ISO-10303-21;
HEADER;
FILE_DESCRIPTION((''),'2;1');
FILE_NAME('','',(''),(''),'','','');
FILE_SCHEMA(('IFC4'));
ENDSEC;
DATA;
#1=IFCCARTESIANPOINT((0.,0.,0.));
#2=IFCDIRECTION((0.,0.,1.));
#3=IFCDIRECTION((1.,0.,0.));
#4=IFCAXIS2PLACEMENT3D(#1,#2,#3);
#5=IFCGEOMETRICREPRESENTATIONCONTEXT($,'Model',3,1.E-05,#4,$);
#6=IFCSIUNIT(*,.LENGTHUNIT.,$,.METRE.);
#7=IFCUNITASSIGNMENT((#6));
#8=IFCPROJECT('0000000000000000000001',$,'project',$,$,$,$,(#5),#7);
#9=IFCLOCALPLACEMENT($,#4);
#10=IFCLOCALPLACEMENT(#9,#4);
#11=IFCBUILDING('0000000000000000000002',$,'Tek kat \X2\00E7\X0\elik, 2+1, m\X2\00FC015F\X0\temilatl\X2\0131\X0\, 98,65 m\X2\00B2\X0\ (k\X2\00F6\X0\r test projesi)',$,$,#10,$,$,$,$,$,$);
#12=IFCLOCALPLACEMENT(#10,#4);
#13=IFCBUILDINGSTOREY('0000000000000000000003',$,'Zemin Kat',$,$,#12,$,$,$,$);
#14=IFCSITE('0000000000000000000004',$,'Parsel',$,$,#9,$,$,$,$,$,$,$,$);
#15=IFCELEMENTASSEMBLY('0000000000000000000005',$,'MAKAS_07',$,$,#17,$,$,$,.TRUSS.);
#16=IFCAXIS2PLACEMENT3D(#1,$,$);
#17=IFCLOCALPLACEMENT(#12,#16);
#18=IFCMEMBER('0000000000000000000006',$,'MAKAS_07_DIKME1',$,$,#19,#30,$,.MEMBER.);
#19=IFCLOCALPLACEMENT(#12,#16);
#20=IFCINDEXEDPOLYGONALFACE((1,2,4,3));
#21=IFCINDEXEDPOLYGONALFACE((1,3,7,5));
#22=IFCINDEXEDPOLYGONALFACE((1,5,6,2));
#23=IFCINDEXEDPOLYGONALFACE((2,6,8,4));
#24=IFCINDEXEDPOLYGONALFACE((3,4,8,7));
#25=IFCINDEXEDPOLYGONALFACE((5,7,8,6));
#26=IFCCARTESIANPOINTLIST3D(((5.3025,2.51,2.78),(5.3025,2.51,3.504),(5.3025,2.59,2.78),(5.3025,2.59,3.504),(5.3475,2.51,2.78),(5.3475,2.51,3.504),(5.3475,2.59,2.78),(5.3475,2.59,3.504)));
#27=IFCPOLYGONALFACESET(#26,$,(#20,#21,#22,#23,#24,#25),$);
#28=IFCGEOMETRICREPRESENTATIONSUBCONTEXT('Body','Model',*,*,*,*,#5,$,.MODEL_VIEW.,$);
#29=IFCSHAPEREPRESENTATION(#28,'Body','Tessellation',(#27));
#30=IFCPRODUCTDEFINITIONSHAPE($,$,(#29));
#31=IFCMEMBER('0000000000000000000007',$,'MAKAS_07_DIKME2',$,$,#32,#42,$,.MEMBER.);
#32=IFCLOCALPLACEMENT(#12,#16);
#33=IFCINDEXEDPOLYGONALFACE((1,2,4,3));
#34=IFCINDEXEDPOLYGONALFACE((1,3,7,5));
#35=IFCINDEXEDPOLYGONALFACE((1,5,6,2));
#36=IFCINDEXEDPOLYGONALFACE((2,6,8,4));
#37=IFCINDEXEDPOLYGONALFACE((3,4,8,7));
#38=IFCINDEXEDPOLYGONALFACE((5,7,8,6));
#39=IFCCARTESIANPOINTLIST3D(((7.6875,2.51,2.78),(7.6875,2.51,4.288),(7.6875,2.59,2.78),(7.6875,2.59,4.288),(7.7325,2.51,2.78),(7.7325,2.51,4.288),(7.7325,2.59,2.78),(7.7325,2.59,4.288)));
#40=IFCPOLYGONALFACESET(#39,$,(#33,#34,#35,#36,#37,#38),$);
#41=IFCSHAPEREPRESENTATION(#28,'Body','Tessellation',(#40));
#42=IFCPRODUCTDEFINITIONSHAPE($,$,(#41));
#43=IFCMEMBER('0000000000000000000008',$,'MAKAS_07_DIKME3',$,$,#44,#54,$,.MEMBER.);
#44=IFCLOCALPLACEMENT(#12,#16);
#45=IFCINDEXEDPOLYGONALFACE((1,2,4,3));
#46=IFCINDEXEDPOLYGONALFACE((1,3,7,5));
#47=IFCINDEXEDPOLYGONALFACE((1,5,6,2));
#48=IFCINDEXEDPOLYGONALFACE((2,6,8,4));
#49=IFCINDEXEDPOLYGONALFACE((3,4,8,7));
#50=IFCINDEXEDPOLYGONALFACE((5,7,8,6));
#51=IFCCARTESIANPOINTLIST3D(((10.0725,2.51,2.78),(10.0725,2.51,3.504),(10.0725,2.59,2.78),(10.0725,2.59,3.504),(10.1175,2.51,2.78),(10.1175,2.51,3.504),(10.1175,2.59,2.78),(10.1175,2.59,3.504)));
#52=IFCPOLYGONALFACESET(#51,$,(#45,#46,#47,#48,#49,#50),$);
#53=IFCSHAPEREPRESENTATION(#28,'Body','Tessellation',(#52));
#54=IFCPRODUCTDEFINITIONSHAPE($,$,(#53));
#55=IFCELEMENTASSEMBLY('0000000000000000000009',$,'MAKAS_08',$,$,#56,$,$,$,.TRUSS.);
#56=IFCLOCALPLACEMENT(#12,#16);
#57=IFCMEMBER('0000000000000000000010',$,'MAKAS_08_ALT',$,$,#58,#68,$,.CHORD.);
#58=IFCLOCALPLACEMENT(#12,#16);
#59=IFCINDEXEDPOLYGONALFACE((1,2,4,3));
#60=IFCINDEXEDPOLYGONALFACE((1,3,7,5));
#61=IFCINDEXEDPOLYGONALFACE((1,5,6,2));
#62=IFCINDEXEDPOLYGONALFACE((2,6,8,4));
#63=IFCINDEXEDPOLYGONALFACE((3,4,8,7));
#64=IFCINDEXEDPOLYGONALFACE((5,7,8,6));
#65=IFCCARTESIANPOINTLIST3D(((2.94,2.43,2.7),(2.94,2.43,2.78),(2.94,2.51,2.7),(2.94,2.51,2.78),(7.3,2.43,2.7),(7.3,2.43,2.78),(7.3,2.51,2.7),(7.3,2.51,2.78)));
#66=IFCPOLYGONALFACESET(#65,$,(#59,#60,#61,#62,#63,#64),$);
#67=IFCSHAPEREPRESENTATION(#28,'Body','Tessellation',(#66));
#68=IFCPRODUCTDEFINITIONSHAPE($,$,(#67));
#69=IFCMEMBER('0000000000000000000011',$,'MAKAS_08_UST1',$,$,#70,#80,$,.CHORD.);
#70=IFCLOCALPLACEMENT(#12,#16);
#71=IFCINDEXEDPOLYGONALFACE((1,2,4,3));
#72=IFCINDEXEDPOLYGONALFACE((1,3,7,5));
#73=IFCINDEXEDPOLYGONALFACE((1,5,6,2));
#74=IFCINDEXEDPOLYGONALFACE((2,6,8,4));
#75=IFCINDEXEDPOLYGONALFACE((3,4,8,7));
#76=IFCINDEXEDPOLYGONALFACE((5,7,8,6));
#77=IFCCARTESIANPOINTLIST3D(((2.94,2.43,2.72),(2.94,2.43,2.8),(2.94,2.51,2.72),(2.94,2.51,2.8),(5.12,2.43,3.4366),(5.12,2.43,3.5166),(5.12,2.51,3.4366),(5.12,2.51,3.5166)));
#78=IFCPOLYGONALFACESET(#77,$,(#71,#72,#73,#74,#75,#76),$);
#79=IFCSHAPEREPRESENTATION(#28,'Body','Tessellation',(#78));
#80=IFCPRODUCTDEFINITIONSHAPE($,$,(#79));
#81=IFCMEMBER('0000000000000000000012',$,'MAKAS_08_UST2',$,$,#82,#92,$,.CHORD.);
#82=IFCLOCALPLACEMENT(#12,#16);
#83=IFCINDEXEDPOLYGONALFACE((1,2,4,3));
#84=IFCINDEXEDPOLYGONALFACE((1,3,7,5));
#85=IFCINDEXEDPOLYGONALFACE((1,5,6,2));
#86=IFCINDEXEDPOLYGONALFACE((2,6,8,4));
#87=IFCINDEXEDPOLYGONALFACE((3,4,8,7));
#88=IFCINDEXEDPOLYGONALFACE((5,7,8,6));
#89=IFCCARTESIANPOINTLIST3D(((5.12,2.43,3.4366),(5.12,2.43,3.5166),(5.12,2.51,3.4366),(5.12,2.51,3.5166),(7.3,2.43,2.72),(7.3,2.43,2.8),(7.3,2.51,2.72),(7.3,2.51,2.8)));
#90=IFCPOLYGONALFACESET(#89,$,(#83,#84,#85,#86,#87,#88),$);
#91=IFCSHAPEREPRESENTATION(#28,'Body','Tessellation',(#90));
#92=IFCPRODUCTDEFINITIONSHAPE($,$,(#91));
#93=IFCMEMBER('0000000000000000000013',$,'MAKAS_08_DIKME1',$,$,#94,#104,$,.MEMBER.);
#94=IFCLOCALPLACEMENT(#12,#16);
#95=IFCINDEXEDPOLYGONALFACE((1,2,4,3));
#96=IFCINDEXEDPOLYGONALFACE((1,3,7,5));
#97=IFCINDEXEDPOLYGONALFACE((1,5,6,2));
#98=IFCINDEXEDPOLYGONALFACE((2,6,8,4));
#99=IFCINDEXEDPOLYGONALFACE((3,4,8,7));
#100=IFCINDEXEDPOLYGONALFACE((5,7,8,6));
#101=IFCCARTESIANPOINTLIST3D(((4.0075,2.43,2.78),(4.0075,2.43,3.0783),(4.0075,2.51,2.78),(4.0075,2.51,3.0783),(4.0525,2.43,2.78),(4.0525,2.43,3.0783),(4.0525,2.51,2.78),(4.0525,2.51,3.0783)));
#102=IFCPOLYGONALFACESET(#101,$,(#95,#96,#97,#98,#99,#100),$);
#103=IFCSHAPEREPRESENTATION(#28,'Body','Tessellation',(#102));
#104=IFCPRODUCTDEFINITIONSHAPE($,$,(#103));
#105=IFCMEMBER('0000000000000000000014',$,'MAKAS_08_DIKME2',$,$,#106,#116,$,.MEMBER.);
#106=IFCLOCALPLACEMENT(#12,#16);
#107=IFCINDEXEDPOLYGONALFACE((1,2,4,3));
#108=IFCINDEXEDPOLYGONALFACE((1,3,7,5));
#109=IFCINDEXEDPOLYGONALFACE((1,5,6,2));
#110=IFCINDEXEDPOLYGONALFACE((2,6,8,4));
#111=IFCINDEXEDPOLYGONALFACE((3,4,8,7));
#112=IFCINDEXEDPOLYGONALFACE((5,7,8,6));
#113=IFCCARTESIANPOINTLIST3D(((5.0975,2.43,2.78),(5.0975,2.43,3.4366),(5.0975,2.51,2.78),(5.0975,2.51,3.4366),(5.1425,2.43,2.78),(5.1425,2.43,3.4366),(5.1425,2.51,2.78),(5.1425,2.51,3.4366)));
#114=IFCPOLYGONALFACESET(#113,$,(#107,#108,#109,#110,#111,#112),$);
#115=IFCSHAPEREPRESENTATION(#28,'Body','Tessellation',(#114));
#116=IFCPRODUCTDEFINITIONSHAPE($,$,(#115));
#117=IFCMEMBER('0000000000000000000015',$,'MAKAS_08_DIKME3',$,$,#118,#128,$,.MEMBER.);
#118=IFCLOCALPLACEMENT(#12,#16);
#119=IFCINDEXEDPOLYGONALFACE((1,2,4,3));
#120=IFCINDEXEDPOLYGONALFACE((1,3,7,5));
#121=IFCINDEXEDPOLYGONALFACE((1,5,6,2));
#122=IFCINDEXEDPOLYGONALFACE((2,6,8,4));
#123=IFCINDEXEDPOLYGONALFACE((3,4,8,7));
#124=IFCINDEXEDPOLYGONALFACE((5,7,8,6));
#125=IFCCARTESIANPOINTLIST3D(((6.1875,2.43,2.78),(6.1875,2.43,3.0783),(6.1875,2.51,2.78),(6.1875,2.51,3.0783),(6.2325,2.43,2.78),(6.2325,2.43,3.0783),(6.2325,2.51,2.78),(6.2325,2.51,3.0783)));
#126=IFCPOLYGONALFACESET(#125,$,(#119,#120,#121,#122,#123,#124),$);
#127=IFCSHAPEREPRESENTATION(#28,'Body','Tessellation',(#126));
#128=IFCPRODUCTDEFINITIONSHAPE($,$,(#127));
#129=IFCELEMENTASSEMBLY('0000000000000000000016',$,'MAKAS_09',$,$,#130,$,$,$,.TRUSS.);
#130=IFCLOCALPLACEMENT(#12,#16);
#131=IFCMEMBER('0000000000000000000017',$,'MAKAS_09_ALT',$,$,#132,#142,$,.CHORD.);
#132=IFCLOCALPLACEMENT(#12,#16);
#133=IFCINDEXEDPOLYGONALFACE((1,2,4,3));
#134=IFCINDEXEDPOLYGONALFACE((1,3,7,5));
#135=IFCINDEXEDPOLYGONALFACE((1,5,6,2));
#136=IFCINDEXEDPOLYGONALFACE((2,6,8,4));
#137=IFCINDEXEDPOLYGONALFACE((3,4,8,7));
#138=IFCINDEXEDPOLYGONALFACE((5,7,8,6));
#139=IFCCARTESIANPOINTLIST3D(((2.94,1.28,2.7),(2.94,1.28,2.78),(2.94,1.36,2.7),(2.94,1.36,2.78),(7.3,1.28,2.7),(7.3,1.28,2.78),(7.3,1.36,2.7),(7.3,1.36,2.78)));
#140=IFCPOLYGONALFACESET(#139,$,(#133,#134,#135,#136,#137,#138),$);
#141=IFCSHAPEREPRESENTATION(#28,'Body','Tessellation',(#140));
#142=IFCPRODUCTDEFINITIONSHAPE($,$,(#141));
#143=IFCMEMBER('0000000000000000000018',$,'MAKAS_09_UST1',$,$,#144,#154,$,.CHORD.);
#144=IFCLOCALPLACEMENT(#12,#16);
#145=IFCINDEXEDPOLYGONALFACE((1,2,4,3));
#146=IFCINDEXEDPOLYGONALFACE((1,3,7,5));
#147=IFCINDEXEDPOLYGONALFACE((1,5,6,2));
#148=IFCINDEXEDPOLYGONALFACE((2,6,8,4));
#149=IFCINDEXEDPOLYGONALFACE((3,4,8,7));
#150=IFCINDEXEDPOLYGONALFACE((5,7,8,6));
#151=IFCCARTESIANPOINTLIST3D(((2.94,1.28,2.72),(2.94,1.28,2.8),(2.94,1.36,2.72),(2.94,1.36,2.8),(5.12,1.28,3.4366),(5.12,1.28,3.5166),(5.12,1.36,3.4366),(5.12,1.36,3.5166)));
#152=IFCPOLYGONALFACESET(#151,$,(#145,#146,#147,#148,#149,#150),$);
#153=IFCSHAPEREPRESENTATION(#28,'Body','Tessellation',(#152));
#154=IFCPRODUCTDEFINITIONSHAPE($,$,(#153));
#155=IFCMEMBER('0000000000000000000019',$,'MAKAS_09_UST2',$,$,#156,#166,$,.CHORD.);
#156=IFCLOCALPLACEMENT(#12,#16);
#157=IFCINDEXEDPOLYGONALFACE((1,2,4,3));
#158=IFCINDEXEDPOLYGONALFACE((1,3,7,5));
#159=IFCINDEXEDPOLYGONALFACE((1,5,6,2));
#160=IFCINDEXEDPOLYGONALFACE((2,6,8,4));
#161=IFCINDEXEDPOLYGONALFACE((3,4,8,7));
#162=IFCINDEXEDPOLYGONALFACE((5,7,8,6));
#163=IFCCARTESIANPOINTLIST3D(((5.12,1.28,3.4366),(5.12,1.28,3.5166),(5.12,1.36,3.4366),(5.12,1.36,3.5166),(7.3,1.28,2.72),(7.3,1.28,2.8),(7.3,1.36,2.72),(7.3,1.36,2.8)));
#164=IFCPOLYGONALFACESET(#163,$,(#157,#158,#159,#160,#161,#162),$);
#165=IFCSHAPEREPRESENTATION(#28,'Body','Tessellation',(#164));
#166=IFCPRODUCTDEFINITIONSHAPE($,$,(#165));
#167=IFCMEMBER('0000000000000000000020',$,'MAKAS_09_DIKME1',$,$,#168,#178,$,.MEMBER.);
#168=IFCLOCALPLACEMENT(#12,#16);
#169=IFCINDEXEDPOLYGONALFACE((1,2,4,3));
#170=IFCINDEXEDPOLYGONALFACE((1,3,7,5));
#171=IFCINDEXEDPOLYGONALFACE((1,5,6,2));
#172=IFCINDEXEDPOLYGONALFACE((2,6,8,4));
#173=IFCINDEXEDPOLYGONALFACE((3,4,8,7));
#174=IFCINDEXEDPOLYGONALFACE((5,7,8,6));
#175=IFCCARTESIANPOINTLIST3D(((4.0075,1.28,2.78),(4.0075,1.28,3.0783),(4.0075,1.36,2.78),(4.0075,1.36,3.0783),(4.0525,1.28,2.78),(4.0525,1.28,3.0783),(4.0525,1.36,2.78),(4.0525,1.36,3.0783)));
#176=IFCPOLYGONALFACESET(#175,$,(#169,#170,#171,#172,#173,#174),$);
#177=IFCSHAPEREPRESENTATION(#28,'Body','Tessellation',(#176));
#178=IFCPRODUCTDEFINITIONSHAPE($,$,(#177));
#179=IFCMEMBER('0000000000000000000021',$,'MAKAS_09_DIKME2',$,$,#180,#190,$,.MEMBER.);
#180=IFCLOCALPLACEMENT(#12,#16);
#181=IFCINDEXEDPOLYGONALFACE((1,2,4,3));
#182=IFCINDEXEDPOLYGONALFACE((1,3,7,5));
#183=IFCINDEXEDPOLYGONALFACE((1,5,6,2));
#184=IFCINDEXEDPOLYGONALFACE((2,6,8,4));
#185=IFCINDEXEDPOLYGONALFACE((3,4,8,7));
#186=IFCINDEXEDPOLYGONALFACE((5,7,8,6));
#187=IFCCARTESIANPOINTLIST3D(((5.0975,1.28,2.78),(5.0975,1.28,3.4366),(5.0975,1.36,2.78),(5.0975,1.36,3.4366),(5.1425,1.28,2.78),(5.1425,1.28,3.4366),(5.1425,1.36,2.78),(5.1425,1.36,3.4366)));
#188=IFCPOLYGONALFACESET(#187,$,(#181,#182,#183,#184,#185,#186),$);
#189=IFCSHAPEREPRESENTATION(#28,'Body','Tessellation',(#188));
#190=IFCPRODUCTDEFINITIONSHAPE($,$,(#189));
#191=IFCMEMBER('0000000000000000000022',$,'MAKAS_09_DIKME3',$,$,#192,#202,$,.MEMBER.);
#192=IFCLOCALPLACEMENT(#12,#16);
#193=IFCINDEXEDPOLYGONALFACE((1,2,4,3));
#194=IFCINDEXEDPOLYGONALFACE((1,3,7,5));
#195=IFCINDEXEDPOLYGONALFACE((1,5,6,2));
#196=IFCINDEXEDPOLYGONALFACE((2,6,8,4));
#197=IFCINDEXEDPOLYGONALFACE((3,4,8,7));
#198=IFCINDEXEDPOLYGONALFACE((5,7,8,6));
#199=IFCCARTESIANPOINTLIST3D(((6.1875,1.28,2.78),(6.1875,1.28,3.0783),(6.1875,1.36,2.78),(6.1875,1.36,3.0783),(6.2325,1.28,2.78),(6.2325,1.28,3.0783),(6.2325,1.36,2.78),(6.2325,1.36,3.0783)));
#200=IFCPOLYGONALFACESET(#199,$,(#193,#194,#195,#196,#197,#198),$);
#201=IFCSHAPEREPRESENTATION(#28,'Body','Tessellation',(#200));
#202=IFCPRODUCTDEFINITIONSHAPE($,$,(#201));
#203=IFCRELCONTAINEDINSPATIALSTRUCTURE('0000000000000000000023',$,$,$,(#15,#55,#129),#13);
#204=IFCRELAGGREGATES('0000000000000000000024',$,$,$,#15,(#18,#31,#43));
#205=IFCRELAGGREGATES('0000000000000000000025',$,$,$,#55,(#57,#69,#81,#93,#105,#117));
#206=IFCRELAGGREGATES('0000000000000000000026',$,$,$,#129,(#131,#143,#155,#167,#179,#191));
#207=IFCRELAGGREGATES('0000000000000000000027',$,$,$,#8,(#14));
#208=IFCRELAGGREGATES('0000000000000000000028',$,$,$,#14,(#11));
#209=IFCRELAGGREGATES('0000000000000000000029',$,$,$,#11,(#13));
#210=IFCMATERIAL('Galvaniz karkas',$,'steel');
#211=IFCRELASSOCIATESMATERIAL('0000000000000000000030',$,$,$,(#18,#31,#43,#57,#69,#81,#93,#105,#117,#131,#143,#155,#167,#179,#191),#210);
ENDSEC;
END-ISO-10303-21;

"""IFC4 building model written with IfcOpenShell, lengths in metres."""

from ifc_helpers import new_model, si_unit, frame, origin_with_axes, place, context, subcontext, project, spatial, line, indexed_curve, outline, extrude, material, element, aggregate, save


model = new_model("IFC4")

# Units and contexts
model_context = context("Model", 3, precision=1e-05, world=origin_with_axes())
body_context = subcontext(model_context, "Body", "Model", "MODEL_VIEW")
ifc_project = project(units=[si_unit("LENGTHUNIT", "METRE")], contexts=[model_context])

# Site, building, storey
site_placement = place(None, origin_with_axes())
site = spatial("IfcSite", under=ifc_project, at=site_placement, Name="Parsel")
building_placement = place(site_placement, origin_with_axes())
building = spatial("IfcBuilding", under=site, at=building_placement, Name="Tek kat çelik, 2+1, müştemilatlı, 98,65 m² (kör test projesi)")
storey_placement = place(building_placement, origin_with_axes())
storey = spatial("IfcBuildingStorey", under=building, at=storey_placement, Name="Zemin Kat")

# Element assemblies, members
ifc_material = material(Name="Galvaniz karkas", Category="steel")
assembly_1_placement = place(storey_placement, origin_with_axes())
assembly_1 = element("IfcElementAssembly", 1, at=assembly_1_placement, inside=storey, Name="MAKAS_07", PredefinedType="TRUSS")
member_1_placement = place(assembly_1_placement, origin_with_axes())
member_1 = element("IfcMember", 2, at=member_1_placement, material=ifc_material, Name="MAKAS_07_DIKME1", PredefinedType="MEMBER", context=body_context, shape_type="SweptSolid", body=[
    extrude(outline(indexed_curve([(5.3025, 2.78), (5.3475, 2.78), (5.3475, 3.504), (5.3025, 3.504)], segments=[line(1, 2, 3, 4, 1)])), frame((0.0, 2.59, 0.0), z_axis=(0.0, -1.0, 0.0), x_axis=(1.0, 0.0, 0.0)), (0.0, 0.0, 1.0), 0.08),
])
member_2_placement = place(assembly_1_placement, origin_with_axes())
member_2 = element("IfcMember", 3, at=member_2_placement, material=ifc_material, Name="MAKAS_07_DIKME2", PredefinedType="MEMBER", context=body_context, shape_type="SweptSolid", body=[
    extrude(outline(indexed_curve([(7.6875, 2.78), (7.7325, 2.78), (7.7325, 4.288), (7.6875, 4.288)], segments=[line(1, 2, 3, 4, 1)])), frame((0.0, 2.59, 0.0), z_axis=(0.0, -1.0, 0.0), x_axis=(1.0, 0.0, 0.0)), (0.0, 0.0, 1.0), 0.08),
])
member_3_placement = place(assembly_1_placement, origin_with_axes())
member_3 = element("IfcMember", 4, at=member_3_placement, material=ifc_material, Name="MAKAS_07_DIKME3", PredefinedType="MEMBER", context=body_context, shape_type="SweptSolid", body=[
    extrude(outline(indexed_curve([(10.0725, 2.78), (10.1175, 2.78), (10.1175, 3.504), (10.0725, 3.504)], segments=[line(1, 2, 3, 4, 1)])), frame((0.0, 2.59, 0.0), z_axis=(0.0, -1.0, 0.0), x_axis=(1.0, 0.0, 0.0)), (0.0, 0.0, 1.0), 0.08),
])
aggregate(assembly_1, [member_1, member_2, member_3])
assembly_2_placement = place(storey_placement, origin_with_axes())
assembly_2 = element("IfcElementAssembly", 5, at=assembly_2_placement, inside=storey, Name="MAKAS_08", PredefinedType="TRUSS")
member_4_placement = place(assembly_2_placement, origin_with_axes())
member_4 = element("IfcMember", 6, at=member_4_placement, material=ifc_material, Name="MAKAS_08_ALT", PredefinedType="CHORD", context=body_context, shape_type="SweptSolid", body=[
    extrude(outline(indexed_curve([(2.94, 2.7), (7.3, 2.7), (7.3, 2.78), (2.94, 2.78)], segments=[line(1, 2, 3, 4, 1)])), frame((0.0, 2.51, 0.0), z_axis=(0.0, -1.0, 0.0), x_axis=(1.0, 0.0, 0.0)), (0.0, 0.0, 1.0), 0.08),
])
member_5_placement = place(assembly_2_placement, origin_with_axes())
member_5 = element("IfcMember", 7, at=member_5_placement, material=ifc_material, Name="MAKAS_08_UST1", PredefinedType="CHORD", context=body_context, shape_type="SweptSolid", body=[
    extrude(outline(indexed_curve([(2.94, 2.72), (5.12, 3.4366), (5.12, 3.5166), (2.94, 2.8)], segments=[line(1, 2, 3, 4, 1)])), frame((0.0, 2.51, 0.0), z_axis=(0.0, -1.0, 0.0), x_axis=(1.0, 0.0, 0.0)), (0.0, 0.0, 1.0), 0.08),
])
member_6_placement = place(assembly_2_placement, origin_with_axes())
member_6 = element("IfcMember", 8, at=member_6_placement, material=ifc_material, Name="MAKAS_08_UST2", PredefinedType="CHORD", context=body_context, shape_type="SweptSolid", body=[
    extrude(outline(indexed_curve([(5.12, 3.4366), (7.3, 2.72), (7.3, 2.8), (5.12, 3.5166)], segments=[line(1, 2, 3, 4, 1)])), frame((0.0, 2.51, 0.0), z_axis=(0.0, -1.0, 0.0), x_axis=(1.0, 0.0, 0.0)), (0.0, 0.0, 1.0), 0.08),
])
member_7_placement = place(assembly_2_placement, origin_with_axes())
member_7 = element("IfcMember", 9, at=member_7_placement, material=ifc_material, Name="MAKAS_08_DIKME1", PredefinedType="MEMBER", context=body_context, shape_type="SweptSolid", body=[
    extrude(outline(indexed_curve([(4.0075, 2.78), (4.0525, 2.78), (4.0525, 3.0783), (4.0075, 3.0783)], segments=[line(1, 2, 3, 4, 1)])), frame((0.0, 2.51, 0.0), z_axis=(0.0, -1.0, 0.0), x_axis=(1.0, 0.0, 0.0)), (0.0, 0.0, 1.0), 0.08),
])
member_8_placement = place(assembly_2_placement, origin_with_axes())
member_8 = element("IfcMember", 10, at=member_8_placement, material=ifc_material, Name="MAKAS_08_DIKME2", PredefinedType="MEMBER", context=body_context, shape_type="SweptSolid", body=[
    extrude(outline(indexed_curve([(5.0975, 2.78), (5.1425, 2.78), (5.1425, 3.4366), (5.0975, 3.4366)], segments=[line(1, 2, 3, 4, 1)])), frame((0.0, 2.51, 0.0), z_axis=(0.0, -1.0, 0.0), x_axis=(1.0, 0.0, 0.0)), (0.0, 0.0, 1.0), 0.08),
])
member_9_placement = place(assembly_2_placement, origin_with_axes())
member_9 = element("IfcMember", 11, at=member_9_placement, material=ifc_material, Name="MAKAS_08_DIKME3", PredefinedType="MEMBER", context=body_context, shape_type="SweptSolid", body=[
    extrude(outline(indexed_curve([(6.1875, 2.78), (6.2325, 2.78), (6.2325, 3.0783), (6.1875, 3.0783)], segments=[line(1, 2, 3, 4, 1)])), frame((0.0, 2.51, 0.0), z_axis=(0.0, -1.0, 0.0), x_axis=(1.0, 0.0, 0.0)), (0.0, 0.0, 1.0), 0.08),
])
aggregate(assembly_2, [member_4, member_5, member_6, member_7, member_8, member_9])
assembly_3_placement = place(storey_placement, origin_with_axes())
assembly_3 = element("IfcElementAssembly", 12, at=assembly_3_placement, inside=storey, Name="MAKAS_09", PredefinedType="TRUSS")
member_10_placement = place(assembly_3_placement, origin_with_axes())
member_10 = element("IfcMember", 13, at=member_10_placement, material=ifc_material, Name="MAKAS_09_ALT", PredefinedType="CHORD", context=body_context, shape_type="SweptSolid", body=[
    extrude(outline(indexed_curve([(2.94, 2.7), (7.3, 2.7), (7.3, 2.78), (2.94, 2.78)], segments=[line(1, 2, 3, 4, 1)])), frame((0.0, 1.36, 0.0), z_axis=(0.0, -1.0, 0.0), x_axis=(1.0, 0.0, 0.0)), (0.0, 0.0, 1.0), 0.08),
])
member_11_placement = place(assembly_3_placement, origin_with_axes())
member_11 = element("IfcMember", 14, at=member_11_placement, material=ifc_material, Name="MAKAS_09_UST1", PredefinedType="CHORD", context=body_context, shape_type="SweptSolid", body=[
    extrude(outline(indexed_curve([(2.94, 2.72), (5.12, 3.4366), (5.12, 3.5166), (2.94, 2.8)], segments=[line(1, 2, 3, 4, 1)])), frame((0.0, 1.36, 0.0), z_axis=(0.0, -1.0, 0.0), x_axis=(1.0, 0.0, 0.0)), (0.0, 0.0, 1.0), 0.08),
])
member_12_placement = place(assembly_3_placement, origin_with_axes())
member_12 = element("IfcMember", 15, at=member_12_placement, material=ifc_material, Name="MAKAS_09_UST2", PredefinedType="CHORD", context=body_context, shape_type="SweptSolid", body=[
    extrude(outline(indexed_curve([(5.12, 3.4366), (7.3, 2.72), (7.3, 2.8), (5.12, 3.5166)], segments=[line(1, 2, 3, 4, 1)])), frame((0.0, 1.36, 0.0), z_axis=(0.0, -1.0, 0.0), x_axis=(1.0, 0.0, 0.0)), (0.0, 0.0, 1.0), 0.08),
])
member_13_placement = place(assembly_3_placement, origin_with_axes())
member_13 = element("IfcMember", 16, at=member_13_placement, material=ifc_material, Name="MAKAS_09_DIKME1", PredefinedType="MEMBER", context=body_context, shape_type="SweptSolid", body=[
    extrude(outline(indexed_curve([(4.0075, 2.78), (4.0525, 2.78), (4.0525, 3.0783), (4.0075, 3.0783)], segments=[line(1, 2, 3, 4, 1)])), frame((0.0, 1.36, 0.0), z_axis=(0.0, -1.0, 0.0), x_axis=(1.0, 0.0, 0.0)), (0.0, 0.0, 1.0), 0.08),
])
member_14_placement = place(assembly_3_placement, origin_with_axes())
member_14 = element("IfcMember", 17, at=member_14_placement, material=ifc_material, Name="MAKAS_09_DIKME2", PredefinedType="MEMBER", context=body_context, shape_type="SweptSolid", body=[
    extrude(outline(indexed_curve([(5.0975, 2.78), (5.1425, 2.78), (5.1425, 3.4366), (5.0975, 3.4366)], segments=[line(1, 2, 3, 4, 1)])), frame((0.0, 1.36, 0.0), z_axis=(0.0, -1.0, 0.0), x_axis=(1.0, 0.0, 0.0)), (0.0, 0.0, 1.0), 0.08),
])
member_15_placement = place(assembly_3_placement, origin_with_axes())
member_15 = element("IfcMember", 18, at=member_15_placement, material=ifc_material, Name="MAKAS_09_DIKME3", PredefinedType="MEMBER", context=body_context, shape_type="SweptSolid", body=[
    extrude(outline(indexed_curve([(6.1875, 2.78), (6.2325, 2.78), (6.2325, 3.0783), (6.1875, 3.0783)], segments=[line(1, 2, 3, 4, 1)])), frame((0.0, 1.36, 0.0), z_axis=(0.0, -1.0, 0.0), x_axis=(1.0, 0.0, 0.0)), (0.0, 0.0, 1.0), 0.08),
])
aggregate(assembly_3, [member_10, member_11, member_12, member_13, member_14, member_15])

save(model, "model.ifc")
